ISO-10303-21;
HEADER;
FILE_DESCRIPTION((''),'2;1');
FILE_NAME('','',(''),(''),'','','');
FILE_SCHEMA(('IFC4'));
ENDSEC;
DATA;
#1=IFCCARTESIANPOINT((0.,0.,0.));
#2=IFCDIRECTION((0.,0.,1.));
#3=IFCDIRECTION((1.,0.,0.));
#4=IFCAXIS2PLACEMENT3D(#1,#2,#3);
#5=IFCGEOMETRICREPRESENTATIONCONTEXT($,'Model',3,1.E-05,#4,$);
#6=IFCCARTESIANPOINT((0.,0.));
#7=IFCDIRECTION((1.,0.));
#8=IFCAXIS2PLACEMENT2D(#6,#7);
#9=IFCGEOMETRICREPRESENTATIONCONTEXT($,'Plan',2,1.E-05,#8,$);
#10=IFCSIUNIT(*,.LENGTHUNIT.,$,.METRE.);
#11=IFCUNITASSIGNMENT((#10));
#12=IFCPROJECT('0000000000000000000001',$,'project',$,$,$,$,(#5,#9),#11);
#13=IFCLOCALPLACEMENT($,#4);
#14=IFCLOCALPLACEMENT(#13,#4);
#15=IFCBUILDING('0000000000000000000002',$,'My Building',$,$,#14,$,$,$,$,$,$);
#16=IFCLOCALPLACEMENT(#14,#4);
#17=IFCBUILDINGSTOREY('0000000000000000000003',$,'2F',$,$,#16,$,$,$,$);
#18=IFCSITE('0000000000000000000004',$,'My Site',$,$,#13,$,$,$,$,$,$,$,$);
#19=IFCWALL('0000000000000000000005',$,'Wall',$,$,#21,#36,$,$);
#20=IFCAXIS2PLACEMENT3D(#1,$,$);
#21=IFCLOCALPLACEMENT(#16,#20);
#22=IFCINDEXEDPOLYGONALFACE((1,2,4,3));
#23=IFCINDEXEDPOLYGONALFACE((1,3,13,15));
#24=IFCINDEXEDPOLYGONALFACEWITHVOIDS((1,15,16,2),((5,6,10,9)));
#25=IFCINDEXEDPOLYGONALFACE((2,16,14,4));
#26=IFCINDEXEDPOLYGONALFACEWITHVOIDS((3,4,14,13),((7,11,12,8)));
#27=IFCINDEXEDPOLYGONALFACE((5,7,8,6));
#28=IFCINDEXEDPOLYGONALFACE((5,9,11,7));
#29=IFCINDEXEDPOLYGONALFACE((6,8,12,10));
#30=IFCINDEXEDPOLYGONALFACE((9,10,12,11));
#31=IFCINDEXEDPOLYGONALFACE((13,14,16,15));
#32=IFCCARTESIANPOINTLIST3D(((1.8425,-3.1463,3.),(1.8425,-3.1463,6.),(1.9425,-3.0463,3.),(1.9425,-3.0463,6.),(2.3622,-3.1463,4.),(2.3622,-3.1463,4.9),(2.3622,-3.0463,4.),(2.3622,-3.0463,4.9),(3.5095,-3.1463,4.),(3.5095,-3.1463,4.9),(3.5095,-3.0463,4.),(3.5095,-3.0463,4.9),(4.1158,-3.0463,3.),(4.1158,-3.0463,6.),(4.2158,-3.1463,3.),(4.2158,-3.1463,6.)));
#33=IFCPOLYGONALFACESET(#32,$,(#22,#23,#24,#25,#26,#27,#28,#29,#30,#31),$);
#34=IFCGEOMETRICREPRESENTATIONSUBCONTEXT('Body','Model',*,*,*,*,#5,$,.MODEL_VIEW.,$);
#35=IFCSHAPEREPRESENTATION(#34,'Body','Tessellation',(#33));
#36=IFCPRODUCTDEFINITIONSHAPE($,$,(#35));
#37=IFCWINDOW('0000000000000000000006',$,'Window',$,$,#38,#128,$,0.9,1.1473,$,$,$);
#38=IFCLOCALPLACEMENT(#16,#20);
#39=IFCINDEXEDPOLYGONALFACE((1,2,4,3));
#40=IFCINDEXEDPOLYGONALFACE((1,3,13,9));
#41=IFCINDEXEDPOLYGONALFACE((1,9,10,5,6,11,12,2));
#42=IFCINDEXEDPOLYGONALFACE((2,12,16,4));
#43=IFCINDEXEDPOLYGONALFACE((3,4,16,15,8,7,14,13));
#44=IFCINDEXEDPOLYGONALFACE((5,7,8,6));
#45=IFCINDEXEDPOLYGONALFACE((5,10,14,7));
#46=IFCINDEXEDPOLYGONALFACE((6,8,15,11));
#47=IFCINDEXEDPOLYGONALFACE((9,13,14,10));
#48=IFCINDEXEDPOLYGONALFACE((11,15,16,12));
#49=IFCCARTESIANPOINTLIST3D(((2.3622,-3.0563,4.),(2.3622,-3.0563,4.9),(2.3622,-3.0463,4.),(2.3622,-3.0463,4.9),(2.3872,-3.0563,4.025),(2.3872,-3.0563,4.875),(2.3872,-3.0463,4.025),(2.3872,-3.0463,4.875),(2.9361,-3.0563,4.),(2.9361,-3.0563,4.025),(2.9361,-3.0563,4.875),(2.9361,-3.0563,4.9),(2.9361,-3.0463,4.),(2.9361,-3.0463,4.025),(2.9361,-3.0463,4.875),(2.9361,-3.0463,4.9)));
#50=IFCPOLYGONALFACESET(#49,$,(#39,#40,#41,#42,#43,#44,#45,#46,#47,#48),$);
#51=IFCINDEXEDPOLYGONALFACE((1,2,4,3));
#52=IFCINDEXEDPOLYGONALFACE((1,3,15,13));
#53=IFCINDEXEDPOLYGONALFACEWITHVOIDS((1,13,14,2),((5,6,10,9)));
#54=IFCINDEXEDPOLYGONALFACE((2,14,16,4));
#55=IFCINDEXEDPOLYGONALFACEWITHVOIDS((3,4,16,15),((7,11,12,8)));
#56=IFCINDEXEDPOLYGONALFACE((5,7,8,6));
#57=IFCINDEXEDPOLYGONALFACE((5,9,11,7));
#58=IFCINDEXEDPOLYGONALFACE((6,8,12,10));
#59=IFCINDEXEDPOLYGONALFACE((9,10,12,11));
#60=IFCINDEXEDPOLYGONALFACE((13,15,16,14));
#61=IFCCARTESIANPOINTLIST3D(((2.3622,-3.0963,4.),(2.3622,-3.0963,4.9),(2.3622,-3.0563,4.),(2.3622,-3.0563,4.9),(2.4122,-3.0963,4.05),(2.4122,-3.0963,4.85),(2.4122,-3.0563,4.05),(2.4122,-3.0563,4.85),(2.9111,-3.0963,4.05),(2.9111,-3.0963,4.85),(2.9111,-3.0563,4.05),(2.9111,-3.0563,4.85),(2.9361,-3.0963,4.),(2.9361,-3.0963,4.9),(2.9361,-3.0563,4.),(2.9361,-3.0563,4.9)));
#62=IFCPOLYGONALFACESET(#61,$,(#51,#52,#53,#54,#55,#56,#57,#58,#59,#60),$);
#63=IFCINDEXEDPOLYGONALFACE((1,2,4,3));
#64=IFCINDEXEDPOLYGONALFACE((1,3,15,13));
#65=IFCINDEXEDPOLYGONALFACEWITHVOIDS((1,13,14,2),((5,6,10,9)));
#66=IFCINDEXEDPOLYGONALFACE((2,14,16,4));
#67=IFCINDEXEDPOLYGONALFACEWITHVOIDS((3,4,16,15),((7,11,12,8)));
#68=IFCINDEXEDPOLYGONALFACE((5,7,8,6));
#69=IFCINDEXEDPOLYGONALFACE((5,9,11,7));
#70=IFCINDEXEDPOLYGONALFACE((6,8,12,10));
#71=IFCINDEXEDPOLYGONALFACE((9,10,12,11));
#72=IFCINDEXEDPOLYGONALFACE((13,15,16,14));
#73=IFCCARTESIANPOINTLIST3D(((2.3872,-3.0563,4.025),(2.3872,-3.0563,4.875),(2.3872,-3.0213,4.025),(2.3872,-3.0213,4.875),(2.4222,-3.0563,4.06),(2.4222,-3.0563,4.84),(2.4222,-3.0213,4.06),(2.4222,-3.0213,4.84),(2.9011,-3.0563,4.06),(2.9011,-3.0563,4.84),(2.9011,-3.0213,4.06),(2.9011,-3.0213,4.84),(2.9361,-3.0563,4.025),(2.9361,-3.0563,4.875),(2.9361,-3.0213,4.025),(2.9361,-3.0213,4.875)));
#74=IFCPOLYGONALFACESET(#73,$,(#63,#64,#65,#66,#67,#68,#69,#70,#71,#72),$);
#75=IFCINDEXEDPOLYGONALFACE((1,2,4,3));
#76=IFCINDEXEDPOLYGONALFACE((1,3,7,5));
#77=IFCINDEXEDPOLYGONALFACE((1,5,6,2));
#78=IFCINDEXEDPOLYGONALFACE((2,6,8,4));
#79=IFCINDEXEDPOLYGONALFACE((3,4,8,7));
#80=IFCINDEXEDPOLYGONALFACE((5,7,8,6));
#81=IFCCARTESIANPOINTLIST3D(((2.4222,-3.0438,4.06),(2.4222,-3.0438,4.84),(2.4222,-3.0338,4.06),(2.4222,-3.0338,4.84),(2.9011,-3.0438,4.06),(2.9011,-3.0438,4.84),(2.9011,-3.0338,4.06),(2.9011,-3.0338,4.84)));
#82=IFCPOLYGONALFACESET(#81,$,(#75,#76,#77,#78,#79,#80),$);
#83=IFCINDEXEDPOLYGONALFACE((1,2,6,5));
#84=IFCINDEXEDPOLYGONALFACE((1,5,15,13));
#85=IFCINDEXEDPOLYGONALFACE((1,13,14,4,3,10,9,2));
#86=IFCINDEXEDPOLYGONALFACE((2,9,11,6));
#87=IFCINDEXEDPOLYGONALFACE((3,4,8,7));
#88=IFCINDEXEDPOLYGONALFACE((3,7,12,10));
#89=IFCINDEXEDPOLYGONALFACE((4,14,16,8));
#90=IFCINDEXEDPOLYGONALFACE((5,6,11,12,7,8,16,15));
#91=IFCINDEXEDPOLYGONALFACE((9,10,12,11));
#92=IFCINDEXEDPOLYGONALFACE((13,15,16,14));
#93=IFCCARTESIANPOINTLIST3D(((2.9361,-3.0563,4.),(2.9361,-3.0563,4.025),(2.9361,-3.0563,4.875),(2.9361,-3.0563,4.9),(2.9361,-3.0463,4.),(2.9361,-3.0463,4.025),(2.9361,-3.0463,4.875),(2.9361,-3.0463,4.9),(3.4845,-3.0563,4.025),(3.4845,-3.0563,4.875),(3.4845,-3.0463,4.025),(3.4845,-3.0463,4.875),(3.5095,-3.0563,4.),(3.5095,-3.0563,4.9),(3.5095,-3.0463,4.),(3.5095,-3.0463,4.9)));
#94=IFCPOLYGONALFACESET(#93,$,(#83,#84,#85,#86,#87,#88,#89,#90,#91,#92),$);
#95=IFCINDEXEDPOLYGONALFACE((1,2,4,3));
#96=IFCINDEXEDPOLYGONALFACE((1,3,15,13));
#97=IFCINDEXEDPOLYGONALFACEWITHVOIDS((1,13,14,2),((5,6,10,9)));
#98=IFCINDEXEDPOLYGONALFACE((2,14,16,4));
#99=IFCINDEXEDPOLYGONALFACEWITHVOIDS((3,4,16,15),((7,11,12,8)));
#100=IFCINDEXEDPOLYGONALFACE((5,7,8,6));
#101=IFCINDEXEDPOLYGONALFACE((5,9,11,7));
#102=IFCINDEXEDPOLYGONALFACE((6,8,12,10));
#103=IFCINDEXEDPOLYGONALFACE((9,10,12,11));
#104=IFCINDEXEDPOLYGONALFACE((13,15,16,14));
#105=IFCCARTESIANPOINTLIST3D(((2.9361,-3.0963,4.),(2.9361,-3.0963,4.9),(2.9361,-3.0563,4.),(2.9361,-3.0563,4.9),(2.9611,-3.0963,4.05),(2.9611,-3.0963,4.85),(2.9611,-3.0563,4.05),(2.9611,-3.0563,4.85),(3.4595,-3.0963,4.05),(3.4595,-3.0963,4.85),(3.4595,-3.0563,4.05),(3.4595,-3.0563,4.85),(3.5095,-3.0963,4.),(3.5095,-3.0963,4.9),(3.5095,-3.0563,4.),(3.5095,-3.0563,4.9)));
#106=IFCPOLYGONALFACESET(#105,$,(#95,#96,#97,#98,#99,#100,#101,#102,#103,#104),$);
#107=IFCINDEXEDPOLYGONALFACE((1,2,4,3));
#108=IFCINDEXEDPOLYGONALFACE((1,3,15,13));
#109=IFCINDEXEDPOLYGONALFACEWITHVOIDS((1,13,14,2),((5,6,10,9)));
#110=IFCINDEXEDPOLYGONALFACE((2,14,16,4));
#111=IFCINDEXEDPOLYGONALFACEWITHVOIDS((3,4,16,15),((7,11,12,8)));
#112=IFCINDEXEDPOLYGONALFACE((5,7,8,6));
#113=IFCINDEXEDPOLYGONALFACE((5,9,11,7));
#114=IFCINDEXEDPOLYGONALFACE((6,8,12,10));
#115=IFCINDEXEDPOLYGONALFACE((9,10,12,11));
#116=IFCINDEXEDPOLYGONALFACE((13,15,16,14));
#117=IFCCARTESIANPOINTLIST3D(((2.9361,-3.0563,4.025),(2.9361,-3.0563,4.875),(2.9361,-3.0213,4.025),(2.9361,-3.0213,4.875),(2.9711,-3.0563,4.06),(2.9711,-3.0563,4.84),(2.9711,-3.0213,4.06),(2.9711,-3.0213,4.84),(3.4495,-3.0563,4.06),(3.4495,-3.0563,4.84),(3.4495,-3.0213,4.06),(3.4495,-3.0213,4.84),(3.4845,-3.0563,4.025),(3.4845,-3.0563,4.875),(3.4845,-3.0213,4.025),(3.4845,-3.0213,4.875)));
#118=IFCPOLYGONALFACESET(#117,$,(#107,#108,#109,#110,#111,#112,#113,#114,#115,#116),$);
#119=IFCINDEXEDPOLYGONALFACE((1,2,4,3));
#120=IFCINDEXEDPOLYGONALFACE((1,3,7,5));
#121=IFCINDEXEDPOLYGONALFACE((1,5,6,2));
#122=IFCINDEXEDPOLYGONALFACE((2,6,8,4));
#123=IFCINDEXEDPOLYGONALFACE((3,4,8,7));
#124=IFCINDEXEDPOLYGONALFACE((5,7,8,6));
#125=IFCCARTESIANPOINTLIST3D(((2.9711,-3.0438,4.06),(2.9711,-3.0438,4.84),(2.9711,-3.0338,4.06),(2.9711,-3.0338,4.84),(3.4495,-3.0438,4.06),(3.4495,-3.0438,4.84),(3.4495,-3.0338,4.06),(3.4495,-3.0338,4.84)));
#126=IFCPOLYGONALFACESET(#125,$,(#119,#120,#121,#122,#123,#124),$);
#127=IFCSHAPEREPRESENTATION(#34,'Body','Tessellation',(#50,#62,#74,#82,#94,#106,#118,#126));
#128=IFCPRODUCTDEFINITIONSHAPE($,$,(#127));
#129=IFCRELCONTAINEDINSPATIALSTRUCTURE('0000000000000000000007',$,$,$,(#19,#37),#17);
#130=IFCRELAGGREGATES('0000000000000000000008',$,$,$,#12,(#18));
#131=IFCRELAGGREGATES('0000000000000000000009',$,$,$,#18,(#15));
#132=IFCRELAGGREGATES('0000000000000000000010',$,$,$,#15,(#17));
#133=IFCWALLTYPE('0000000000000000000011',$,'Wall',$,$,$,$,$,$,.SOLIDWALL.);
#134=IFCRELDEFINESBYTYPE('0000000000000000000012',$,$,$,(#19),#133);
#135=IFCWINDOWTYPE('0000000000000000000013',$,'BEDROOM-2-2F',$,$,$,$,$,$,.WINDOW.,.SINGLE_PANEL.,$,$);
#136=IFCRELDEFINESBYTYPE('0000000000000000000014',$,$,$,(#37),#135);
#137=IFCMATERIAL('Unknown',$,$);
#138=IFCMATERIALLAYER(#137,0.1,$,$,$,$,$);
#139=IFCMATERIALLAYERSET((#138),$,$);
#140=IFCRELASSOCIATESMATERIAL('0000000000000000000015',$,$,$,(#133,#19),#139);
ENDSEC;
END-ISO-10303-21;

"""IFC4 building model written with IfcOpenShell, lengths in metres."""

from ifc_helpers import new_model, entity, si_unit, frame, origin_with_axes, origin_2d_with_axis, place, context, subcontext, project, spatial, line, indexed_curve, outline, extrude, shape, source, transform, mapped, material, layer, layer_set, layer_usage, type_object, type_shapes, element, fill, save


model = new_model("IFC4")

# Units and contexts
model_context = context("Model", 3, precision=1e-05, world=origin_with_axes())
plan_context = context("Plan", 2, precision=1e-05, world=origin_2d_with_axis())
body_context_1 = subcontext(model_context, "Body", "Model", "MODEL_VIEW")
body_context_2 = subcontext(plan_context, "Body", "Plan", "PLAN_VIEW")
ifc_project = project(units=[si_unit("LENGTHUNIT", "METRE")], contexts=[model_context, plan_context])

# Site, building, storey
site_placement = place(None, origin_with_axes())
site = spatial("IfcSite", under=ifc_project, at=site_placement, Name="My Site")
building_placement = place(site_placement, origin_with_axes())
building = spatial("IfcBuilding", under=site, at=building_placement, Name="My Building")
storey_placement = place(building_placement, origin_with_axes())
storey = spatial("IfcBuildingStorey", under=building, at=storey_placement, Name="2F")

# Shared definitions
ifc_material_1 = material(Name="Unknown")

# Shared definitions
ifc_layer_1 = layer(ifc_material_1, 0.1)
ifc_layer_set_1 = layer_set([ifc_layer_1])
wall_type = type_object("IfcWallType", Name="Wall", PredefinedType="SOLIDWALL", material=ifc_layer_set_1)

# Wall, opening, window
ifc_layer_usage_1 = layer_usage(ifc_layer_set_1, "AXIS2", "POSITIVE", 0.0)
wall_1_placement = place(storey_placement, frame((1.8425, -3.1463, 3.0), z_axis=(0.0, 0.0, 1.0), x_axis=(1.0, 0.0, 0.0)))
wall_1 = element("IfcWall", 1, at=wall_1_placement, inside=storey, type_object=wall_type, material=ifc_layer_usage_1, Name="Wall", context=body_context_1, shape_type="SweptSolid", body=[
    extrude(outline(indexed_curve([(0.0, 0.0), (0.1, 0.1), (2.2734, 0.1), (2.3734, 0.0)], segments=[line(1, 2, 3, 4, 1)])), origin_with_axes(), (0.0, 0.0, 1.0), 3.0),
])
shared_shape_1 = source(origin_with_axes(), body_context_1, "Body", "SweptSolid", [
    extrude(outline(indexed_curve([(0.0, 0.0), (1.1473, 0.0), (1.1473, 0.9), (0.0, 0.9)], segments=[line(1, 2, 3, 4, 1)])), frame((0.0, -0.6, 0.0), z_axis=(0.0, -1.0, 0.0), x_axis=(1.0, 0.0, 0.0)), (0.0, 0.0, -1.0), 1.2),
])
opening_1_placement = place(wall_1_placement, frame((0.5197, 0.0, 1.0), z_axis=(0.0, 0.0, 1.0), x_axis=(1.0, 0.0, 0.0)))
opening_1 = element("IfcOpeningElement", 2, at=opening_1_placement, cuts=wall_1, PredefinedType="OPENING", context=body_context_1, shape_type="MappedRepresentation", body=[
    mapped(shared_shape_1, transform((0.0, 0.0, 0.0), x_axis=(1.0, 0.0, 0.0), y_axis=(0.0, 1.0, 0.0), z_axis=(0.0, 0.0, 1.0), scale=1.0)),
])
window_type_1 = type_object("IfcWindowType", Name="BEDROOM-2-2F", PartitioningType="SINGLE_PANEL", PredefinedType="WINDOW")
shared_shape_2 = source(origin_with_axes(), body_context_1, "Body", "SweptSolid", [
    extrude(outline(indexed_curve([(0.5739, 0.0), (0.0, 0.0), (0.0, 0.9), (0.5739, 0.9), (0.5739, 0.875), (0.025, 0.875), (0.025, 0.025), (0.5739, 0.025)], segments=[line(1, 2, 3, 4, 5, 6, 7, 8, 1)])), frame((0.0, 0.09, 0.0), z_axis=(0.0, -1.0, 0.0), x_axis=(1.0, 0.0, 0.0)), (0.0, 0.0, -1.0), 0.01),
    extrude(outline(indexed_curve([(0.0, 0.0), (0.5739, 0.0), (0.5739, 0.9), (0.0, 0.9)], segments=[line(1, 2, 3, 4, 1)]), holes=[indexed_curve([(0.05, 0.05), (0.5489, 0.05), (0.5489, 0.85), (0.05, 0.85)], segments=[line(1, 2, 3, 4, 1)])]), frame((0.0, 0.05, 0.0), z_axis=(0.0, -1.0, 0.0), x_axis=(1.0, 0.0, 0.0)), (0.0, 0.0, -1.0), 0.04),
    extrude(outline(indexed_curve([(0.0, 0.0), (0.5489, 0.0), (0.5489, 0.85), (0.0, 0.85)], segments=[line(1, 2, 3, 4, 1)]), holes=[indexed_curve([(0.035, 0.035), (0.5139, 0.035), (0.5139, 0.815), (0.035, 0.815)], segments=[line(1, 2, 3, 4, 1)])]), frame((0.025, 0.09, 0.025), z_axis=(0.0, -1.0, 0.0), x_axis=(1.0, 0.0, 0.0)), (0.0, 0.0, -1.0), 0.035),
    extrude(outline(indexed_curve([(0.035, 0.035), (0.5139, 0.035), (0.5139, 0.815), (0.035, 0.815)], segments=[line(1, 2, 3, 4, 1)])), frame((0.025, 0.1025, 0.025), z_axis=(0.0, -1.0, 0.0), x_axis=(1.0, 0.0, 0.0)), (0.0, 0.0, -1.0), 0.01),
    extrude(outline(indexed_curve([(0.0, 0.9), (0.5733, 0.9), (0.5733, 0.0), (0.0, 0.0), (0.0, 0.025), (0.5483, 0.025), (0.5483, 0.875), (0.0, 0.875)], segments=[line(1, 2, 3, 4, 5, 6, 7, 8, 1)])), frame((0.5739, 0.09, 0.0), z_axis=(0.0, -1.0, 0.0), x_axis=(1.0, 0.0, 0.0)), (0.0, 0.0, -1.0), 0.01),
    extrude(outline(indexed_curve([(0.0, 0.0), (0.5733, 0.0), (0.5733, 0.9), (0.0, 0.9)], segments=[line(1, 2, 3, 4, 1)]), holes=[indexed_curve([(0.025, 0.05), (0.5233, 0.05), (0.5233, 0.85), (0.025, 0.85)], segments=[line(1, 2, 3, 4, 1)])]), frame((0.5739, 0.05, 0.0), z_axis=(0.0, -1.0, 0.0), x_axis=(1.0, 0.0, 0.0)), (0.0, 0.0, -1.0), 0.04),
    extrude(outline(indexed_curve([(0.0, 0.0), (0.5483, 0.0), (0.5483, 0.85), (0.0, 0.85)], segments=[line(1, 2, 3, 4, 1)]), holes=[indexed_curve([(0.035, 0.035), (0.5133, 0.035), (0.5133, 0.815), (0.035, 0.815)], segments=[line(1, 2, 3, 4, 1)])]), frame((0.5739, 0.09, 0.025), z_axis=(0.0, -1.0, 0.0), x_axis=(1.0, 0.0, 0.0)), (0.0, 0.0, -1.0), 0.035),
    extrude(outline(indexed_curve([(0.035, 0.035), (0.5133, 0.035), (0.5133, 0.815), (0.035, 0.815)], segments=[line(1, 2, 3, 4, 1)])), frame((0.5739, 0.1025, 0.025), z_axis=(0.0, -1.0, 0.0), x_axis=(1.0, 0.0, 0.0)), (0.0, 0.0, -1.0), 0.01),
])
shared_shape_3 = source(origin_with_axes(), body_context_2, "Body", "Curve2D", [
    entity("IfcIndexedPolyCurve", entity("IfcCartesianPointList2D", [[0.05, 0.05], [0.5489, 0.05]])),
    entity("IfcIndexedPolyCurve", entity("IfcCartesianPointList2D", [[0.0, 0.1], [0.025, 0.1], [0.025, 0.09], [0.05, 0.09], [0.05, 0.05], [0.0, 0.05]]), [entity("IfcLineIndex", [1, 2, 3, 4, 5, 6, 1])]),
    entity("IfcIndexedPolyCurve", entity("IfcCartesianPointList2D", [[0.5739, 0.1], [0.5739, 0.1], [0.5739, 0.09], [0.5489, 0.09], [0.5489, 0.05], [0.5739, 0.05]])),
    entity("IfcIndexedPolyCurve", entity("IfcCartesianPointList2D", [[0.025, 0.09], [0.06, 0.09], [0.06, 0.125], [0.025, 0.125]]), [entity("IfcLineIndex", [1, 2, 3, 4, 1])]),
    entity("IfcIndexedPolyCurve", entity("IfcCartesianPointList2D", [[0.5739, 0.09], [0.5389, 0.09], [0.5389, 0.125], [0.5739, 0.125]]), [entity("IfcLineIndex", [1, 2, 3, 4, 1])]),
    entity("IfcIndexedPolyCurve", entity("IfcCartesianPointList2D", [[0.06, 0.09], [0.5389, 0.09]])),
    entity("IfcIndexedPolyCurve", entity("IfcCartesianPointList2D", [[0.06, 0.125], [0.5389, 0.125]])),
    entity("IfcIndexedPolyCurve", entity("IfcCartesianPointList2D", [[0.06, 0.1075], [0.5389, 0.1075]])),
    entity("IfcIndexedPolyCurve", entity("IfcCartesianPointList2D", [[0.5989, 0.05], [1.0973, 0.05]])),
    entity("IfcIndexedPolyCurve", entity("IfcCartesianPointList2D", [[0.5739, 0.1], [0.5739, 0.1], [0.5739, 0.09], [0.5989, 0.09], [0.5989, 0.05], [0.5739, 0.05]])),
    entity("IfcIndexedPolyCurve", entity("IfcCartesianPointList2D", [[1.1473, 0.1], [1.1223, 0.1], [1.1223, 0.09], [1.0973, 0.09], [1.0973, 0.05], [1.1473, 0.05]]), [entity("IfcLineIndex", [1, 2, 3, 4, 5, 6, 1])]),
    entity("IfcIndexedPolyCurve", entity("IfcCartesianPointList2D", [[0.5739, 0.09], [0.6089, 0.09], [0.6089, 0.125], [0.5739, 0.125]]), [entity("IfcLineIndex", [1, 2, 3, 4, 1])]),
    entity("IfcIndexedPolyCurve", entity("IfcCartesianPointList2D", [[1.1223, 0.09], [1.0873, 0.09], [1.0873, 0.125], [1.1223, 0.125]]), [entity("IfcLineIndex", [1, 2, 3, 4, 1])]),
    entity("IfcIndexedPolyCurve", entity("IfcCartesianPointList2D", [[0.6089, 0.09], [1.0873, 0.09]])),
    entity("IfcIndexedPolyCurve", entity("IfcCartesianPointList2D", [[0.6089, 0.125], [1.0873, 0.125]])),
    entity("IfcIndexedPolyCurve", entity("IfcCartesianPointList2D", [[0.6089, 0.1075], [1.0873, 0.1075]])),
])
type_shapes(window_type_1, [shared_shape_2, shared_shape_3])
window_1_placement = place(opening_1_placement, origin_with_axes())
window_1 = element("IfcWindow", 3, at=window_1_placement, inside=storey, type_object=window_type_1, Name="Window", OverallHeight=0.9, OverallWidth=1.1473, shapes=[
    shape(body_context_1, "Body", "MappedRepresentation", [mapped(shared_shape_2, transform((0.0, 0.0, 0.0), x_axis=(1.0, 0.0, 0.0), y_axis=(0.0, 1.0, 0.0), z_axis=(0.0, 0.0, 1.0), scale=1.0))]),
    shape(body_context_2, "Body", "MappedRepresentation", [mapped(shared_shape_3, transform((0.0, 0.0, 0.0), x_axis=(1.0, 0.0, 0.0), y_axis=(0.0, 1.0, 0.0), z_axis=(0.0, 0.0, 1.0), scale=1.0))]),
])
fill(opening_1, window_1)

save(model, "model.ifc")
